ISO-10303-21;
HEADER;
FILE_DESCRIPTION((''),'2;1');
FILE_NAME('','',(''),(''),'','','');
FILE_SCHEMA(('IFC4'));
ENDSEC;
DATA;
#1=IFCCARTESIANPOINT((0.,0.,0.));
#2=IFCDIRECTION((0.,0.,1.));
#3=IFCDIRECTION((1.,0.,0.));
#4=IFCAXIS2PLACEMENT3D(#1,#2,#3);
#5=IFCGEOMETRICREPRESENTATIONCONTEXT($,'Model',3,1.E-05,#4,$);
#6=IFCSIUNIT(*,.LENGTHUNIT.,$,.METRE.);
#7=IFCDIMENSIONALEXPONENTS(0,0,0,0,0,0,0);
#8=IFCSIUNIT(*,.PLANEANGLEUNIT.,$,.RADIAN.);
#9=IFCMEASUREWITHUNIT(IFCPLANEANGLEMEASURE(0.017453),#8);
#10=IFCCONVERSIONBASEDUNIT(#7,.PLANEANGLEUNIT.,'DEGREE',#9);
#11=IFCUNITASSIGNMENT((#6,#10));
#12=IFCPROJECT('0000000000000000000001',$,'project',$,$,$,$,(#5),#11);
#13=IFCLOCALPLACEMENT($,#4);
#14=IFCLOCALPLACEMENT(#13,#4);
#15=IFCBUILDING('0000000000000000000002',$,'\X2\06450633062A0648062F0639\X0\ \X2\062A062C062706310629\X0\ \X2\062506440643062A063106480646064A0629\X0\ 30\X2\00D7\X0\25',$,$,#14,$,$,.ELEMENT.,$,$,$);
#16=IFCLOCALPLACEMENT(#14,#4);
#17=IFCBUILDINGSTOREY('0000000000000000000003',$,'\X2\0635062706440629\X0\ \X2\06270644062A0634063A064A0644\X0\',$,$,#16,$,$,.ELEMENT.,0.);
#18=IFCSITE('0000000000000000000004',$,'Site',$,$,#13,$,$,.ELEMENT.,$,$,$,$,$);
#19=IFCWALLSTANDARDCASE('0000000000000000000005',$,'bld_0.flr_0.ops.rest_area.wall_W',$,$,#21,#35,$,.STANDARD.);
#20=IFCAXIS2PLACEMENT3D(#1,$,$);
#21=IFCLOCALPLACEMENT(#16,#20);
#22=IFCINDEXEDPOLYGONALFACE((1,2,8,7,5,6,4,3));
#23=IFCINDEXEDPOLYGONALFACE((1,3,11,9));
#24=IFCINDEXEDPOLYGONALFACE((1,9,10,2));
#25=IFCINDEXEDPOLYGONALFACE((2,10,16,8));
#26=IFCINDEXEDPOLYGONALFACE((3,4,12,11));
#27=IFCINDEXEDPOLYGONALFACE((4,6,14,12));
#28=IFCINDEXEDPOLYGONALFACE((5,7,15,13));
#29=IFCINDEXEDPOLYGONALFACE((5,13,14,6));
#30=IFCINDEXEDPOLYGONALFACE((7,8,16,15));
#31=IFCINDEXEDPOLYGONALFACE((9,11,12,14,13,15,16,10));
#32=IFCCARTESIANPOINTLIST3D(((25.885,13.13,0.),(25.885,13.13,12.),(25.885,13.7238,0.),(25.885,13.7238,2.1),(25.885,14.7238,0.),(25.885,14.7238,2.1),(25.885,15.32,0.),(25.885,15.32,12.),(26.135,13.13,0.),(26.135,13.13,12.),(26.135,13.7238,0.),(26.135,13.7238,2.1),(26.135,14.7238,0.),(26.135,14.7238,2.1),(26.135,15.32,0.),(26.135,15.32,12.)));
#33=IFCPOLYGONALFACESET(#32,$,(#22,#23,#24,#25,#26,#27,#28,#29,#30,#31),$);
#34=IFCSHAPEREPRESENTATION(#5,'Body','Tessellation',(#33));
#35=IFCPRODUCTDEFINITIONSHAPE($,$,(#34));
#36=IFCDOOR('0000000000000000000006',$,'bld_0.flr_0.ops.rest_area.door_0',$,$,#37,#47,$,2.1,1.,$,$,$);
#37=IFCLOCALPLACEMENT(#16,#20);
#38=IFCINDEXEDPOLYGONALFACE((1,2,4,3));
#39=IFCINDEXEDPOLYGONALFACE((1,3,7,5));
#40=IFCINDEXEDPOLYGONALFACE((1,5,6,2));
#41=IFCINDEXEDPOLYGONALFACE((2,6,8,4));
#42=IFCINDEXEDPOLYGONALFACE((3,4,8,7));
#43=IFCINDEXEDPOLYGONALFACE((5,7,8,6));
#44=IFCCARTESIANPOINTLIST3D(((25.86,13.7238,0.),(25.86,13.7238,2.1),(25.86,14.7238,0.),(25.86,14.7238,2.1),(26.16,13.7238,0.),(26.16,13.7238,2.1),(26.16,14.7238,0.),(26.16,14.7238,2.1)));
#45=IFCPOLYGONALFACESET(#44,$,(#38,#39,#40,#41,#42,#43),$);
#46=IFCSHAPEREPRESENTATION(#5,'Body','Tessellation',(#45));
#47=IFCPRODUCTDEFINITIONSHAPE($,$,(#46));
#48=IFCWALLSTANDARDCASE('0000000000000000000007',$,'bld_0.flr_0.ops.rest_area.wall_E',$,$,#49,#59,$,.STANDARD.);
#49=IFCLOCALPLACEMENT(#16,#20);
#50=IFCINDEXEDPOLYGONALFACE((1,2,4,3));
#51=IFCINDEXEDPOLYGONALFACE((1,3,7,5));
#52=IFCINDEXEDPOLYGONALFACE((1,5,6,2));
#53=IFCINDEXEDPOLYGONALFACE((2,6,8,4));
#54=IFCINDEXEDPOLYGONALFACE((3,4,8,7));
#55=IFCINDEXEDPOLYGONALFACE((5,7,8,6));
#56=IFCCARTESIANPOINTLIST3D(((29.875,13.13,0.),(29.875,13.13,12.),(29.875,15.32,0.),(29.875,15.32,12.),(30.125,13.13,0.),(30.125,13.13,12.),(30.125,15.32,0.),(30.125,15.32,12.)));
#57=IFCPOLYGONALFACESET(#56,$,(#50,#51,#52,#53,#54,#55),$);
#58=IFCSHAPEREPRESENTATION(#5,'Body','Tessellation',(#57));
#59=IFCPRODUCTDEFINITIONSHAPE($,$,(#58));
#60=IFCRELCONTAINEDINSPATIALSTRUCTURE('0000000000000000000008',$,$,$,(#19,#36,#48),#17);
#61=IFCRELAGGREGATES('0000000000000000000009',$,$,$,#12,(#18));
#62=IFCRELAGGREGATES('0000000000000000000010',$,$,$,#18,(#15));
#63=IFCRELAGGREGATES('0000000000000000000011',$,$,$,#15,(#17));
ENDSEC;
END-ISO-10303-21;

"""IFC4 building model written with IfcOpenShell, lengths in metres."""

from ifc_helpers import new_model, entity, si_unit, converted_unit, frame, frame_2d, origin_with_axes, origin_2d_with_axis, place, context, project, spatial, rectangle, extrude, element, fill, save


model = new_model("IFC4")

# Units and contexts
model_context = context("Model", 3, precision=1e-05, world=origin_with_axes())
ifc_project = project(units=[si_unit("LENGTHUNIT", "METRE"), converted_unit("PLANEANGLEUNIT", "DEGREE", entity("IfcPlaneAngleMeasure", 0.017453), si_unit("PLANEANGLEUNIT", "RADIAN"), dimensions=[0, 0, 0, 0, 0, 0, 0])], contexts=[model_context])

# Site, building, storey
site_placement = place(None, origin_with_axes())
site = spatial("IfcSite", under=ifc_project, at=site_placement, Name="Site", CompositionType="ELEMENT")
building_placement = place(site_placement, origin_with_axes())
building = spatial("IfcBuilding", under=site, at=building_placement, Name="مستودع تجارة إلكترونية 30×25", CompositionType="ELEMENT")
storey_placement = place(building_placement, origin_with_axes())
storey = spatial("IfcBuildingStorey", under=building, at=storey_placement, Name="صالة التشغيل", CompositionType="ELEMENT", Elevation=0.0)

# Wall, opening, door
wall_1_placement = place(storey_placement, frame((26.01, 13.13, 0.0), z_axis=(0.0, 0.0, 1.0), x_axis=(0.0, 1.0, 0.0)))
wall_1 = element("IfcWallStandardCase", 1, at=wall_1_placement, inside=storey, Name="bld_0.flr_0.ops.rest_area.wall_W", PredefinedType="STANDARD", context=model_context, shape_type="SweptSolid", body=[
    extrude(rectangle(XDim=2.19, YDim=0.25, at=frame_2d((1.095, 0.0), x_axis=(1.0, 0.0))), origin_with_axes(), (0.0, 0.0, 1.0), 12.0),
])
opening_1_placement = place(storey_placement, frame((26.01, 14.2238, 0.0), z_axis=(0.0, 0.0, 1.0), x_axis=(0.0, 1.0, 0.0)))
opening_1 = element("IfcOpeningElement", 2, at=opening_1_placement, cuts=wall_1, PredefinedType="OPENING", context=model_context, shape_type="SweptSolid", body=[
    extrude(rectangle(XDim=1.0, YDim=0.3, at=origin_2d_with_axis()), origin_with_axes(), (0.0, 0.0, 1.0), 2.1),
])
door_1_placement = place(storey_placement, frame((26.01, 14.2238, 0.0), z_axis=(0.0, 0.0, 1.0), x_axis=(0.0, 1.0, 0.0)))
door_1 = element("IfcDoor", 3, at=door_1_placement, inside=storey, Name="bld_0.flr_0.ops.rest_area.door_0", OverallHeight=2.1, OverallWidth=1.0, context=model_context, shape_type="SweptSolid", body=[
    extrude(rectangle(XDim=1.0, YDim=0.3, at=origin_2d_with_axis()), origin_with_axes(), (0.0, 0.0, 1.0), 2.1),
])
fill(opening_1, door_1)

# Wall
wall_2_placement = place(storey_placement, frame((30.0, 13.13, 0.0), z_axis=(0.0, 0.0, 1.0), x_axis=(0.0, 1.0, 0.0)))
element("IfcWallStandardCase", 4, at=wall_2_placement, inside=storey, Name="bld_0.flr_0.ops.rest_area.wall_E", PredefinedType="STANDARD", context=model_context, shape_type="SweptSolid", body=[
    extrude(rectangle(XDim=2.19, YDim=0.25, at=frame_2d((1.095, 0.0), x_axis=(1.0, 0.0))), origin_with_axes(), (0.0, 0.0, 1.0), 12.0),
])

save(model, "model.ifc")
